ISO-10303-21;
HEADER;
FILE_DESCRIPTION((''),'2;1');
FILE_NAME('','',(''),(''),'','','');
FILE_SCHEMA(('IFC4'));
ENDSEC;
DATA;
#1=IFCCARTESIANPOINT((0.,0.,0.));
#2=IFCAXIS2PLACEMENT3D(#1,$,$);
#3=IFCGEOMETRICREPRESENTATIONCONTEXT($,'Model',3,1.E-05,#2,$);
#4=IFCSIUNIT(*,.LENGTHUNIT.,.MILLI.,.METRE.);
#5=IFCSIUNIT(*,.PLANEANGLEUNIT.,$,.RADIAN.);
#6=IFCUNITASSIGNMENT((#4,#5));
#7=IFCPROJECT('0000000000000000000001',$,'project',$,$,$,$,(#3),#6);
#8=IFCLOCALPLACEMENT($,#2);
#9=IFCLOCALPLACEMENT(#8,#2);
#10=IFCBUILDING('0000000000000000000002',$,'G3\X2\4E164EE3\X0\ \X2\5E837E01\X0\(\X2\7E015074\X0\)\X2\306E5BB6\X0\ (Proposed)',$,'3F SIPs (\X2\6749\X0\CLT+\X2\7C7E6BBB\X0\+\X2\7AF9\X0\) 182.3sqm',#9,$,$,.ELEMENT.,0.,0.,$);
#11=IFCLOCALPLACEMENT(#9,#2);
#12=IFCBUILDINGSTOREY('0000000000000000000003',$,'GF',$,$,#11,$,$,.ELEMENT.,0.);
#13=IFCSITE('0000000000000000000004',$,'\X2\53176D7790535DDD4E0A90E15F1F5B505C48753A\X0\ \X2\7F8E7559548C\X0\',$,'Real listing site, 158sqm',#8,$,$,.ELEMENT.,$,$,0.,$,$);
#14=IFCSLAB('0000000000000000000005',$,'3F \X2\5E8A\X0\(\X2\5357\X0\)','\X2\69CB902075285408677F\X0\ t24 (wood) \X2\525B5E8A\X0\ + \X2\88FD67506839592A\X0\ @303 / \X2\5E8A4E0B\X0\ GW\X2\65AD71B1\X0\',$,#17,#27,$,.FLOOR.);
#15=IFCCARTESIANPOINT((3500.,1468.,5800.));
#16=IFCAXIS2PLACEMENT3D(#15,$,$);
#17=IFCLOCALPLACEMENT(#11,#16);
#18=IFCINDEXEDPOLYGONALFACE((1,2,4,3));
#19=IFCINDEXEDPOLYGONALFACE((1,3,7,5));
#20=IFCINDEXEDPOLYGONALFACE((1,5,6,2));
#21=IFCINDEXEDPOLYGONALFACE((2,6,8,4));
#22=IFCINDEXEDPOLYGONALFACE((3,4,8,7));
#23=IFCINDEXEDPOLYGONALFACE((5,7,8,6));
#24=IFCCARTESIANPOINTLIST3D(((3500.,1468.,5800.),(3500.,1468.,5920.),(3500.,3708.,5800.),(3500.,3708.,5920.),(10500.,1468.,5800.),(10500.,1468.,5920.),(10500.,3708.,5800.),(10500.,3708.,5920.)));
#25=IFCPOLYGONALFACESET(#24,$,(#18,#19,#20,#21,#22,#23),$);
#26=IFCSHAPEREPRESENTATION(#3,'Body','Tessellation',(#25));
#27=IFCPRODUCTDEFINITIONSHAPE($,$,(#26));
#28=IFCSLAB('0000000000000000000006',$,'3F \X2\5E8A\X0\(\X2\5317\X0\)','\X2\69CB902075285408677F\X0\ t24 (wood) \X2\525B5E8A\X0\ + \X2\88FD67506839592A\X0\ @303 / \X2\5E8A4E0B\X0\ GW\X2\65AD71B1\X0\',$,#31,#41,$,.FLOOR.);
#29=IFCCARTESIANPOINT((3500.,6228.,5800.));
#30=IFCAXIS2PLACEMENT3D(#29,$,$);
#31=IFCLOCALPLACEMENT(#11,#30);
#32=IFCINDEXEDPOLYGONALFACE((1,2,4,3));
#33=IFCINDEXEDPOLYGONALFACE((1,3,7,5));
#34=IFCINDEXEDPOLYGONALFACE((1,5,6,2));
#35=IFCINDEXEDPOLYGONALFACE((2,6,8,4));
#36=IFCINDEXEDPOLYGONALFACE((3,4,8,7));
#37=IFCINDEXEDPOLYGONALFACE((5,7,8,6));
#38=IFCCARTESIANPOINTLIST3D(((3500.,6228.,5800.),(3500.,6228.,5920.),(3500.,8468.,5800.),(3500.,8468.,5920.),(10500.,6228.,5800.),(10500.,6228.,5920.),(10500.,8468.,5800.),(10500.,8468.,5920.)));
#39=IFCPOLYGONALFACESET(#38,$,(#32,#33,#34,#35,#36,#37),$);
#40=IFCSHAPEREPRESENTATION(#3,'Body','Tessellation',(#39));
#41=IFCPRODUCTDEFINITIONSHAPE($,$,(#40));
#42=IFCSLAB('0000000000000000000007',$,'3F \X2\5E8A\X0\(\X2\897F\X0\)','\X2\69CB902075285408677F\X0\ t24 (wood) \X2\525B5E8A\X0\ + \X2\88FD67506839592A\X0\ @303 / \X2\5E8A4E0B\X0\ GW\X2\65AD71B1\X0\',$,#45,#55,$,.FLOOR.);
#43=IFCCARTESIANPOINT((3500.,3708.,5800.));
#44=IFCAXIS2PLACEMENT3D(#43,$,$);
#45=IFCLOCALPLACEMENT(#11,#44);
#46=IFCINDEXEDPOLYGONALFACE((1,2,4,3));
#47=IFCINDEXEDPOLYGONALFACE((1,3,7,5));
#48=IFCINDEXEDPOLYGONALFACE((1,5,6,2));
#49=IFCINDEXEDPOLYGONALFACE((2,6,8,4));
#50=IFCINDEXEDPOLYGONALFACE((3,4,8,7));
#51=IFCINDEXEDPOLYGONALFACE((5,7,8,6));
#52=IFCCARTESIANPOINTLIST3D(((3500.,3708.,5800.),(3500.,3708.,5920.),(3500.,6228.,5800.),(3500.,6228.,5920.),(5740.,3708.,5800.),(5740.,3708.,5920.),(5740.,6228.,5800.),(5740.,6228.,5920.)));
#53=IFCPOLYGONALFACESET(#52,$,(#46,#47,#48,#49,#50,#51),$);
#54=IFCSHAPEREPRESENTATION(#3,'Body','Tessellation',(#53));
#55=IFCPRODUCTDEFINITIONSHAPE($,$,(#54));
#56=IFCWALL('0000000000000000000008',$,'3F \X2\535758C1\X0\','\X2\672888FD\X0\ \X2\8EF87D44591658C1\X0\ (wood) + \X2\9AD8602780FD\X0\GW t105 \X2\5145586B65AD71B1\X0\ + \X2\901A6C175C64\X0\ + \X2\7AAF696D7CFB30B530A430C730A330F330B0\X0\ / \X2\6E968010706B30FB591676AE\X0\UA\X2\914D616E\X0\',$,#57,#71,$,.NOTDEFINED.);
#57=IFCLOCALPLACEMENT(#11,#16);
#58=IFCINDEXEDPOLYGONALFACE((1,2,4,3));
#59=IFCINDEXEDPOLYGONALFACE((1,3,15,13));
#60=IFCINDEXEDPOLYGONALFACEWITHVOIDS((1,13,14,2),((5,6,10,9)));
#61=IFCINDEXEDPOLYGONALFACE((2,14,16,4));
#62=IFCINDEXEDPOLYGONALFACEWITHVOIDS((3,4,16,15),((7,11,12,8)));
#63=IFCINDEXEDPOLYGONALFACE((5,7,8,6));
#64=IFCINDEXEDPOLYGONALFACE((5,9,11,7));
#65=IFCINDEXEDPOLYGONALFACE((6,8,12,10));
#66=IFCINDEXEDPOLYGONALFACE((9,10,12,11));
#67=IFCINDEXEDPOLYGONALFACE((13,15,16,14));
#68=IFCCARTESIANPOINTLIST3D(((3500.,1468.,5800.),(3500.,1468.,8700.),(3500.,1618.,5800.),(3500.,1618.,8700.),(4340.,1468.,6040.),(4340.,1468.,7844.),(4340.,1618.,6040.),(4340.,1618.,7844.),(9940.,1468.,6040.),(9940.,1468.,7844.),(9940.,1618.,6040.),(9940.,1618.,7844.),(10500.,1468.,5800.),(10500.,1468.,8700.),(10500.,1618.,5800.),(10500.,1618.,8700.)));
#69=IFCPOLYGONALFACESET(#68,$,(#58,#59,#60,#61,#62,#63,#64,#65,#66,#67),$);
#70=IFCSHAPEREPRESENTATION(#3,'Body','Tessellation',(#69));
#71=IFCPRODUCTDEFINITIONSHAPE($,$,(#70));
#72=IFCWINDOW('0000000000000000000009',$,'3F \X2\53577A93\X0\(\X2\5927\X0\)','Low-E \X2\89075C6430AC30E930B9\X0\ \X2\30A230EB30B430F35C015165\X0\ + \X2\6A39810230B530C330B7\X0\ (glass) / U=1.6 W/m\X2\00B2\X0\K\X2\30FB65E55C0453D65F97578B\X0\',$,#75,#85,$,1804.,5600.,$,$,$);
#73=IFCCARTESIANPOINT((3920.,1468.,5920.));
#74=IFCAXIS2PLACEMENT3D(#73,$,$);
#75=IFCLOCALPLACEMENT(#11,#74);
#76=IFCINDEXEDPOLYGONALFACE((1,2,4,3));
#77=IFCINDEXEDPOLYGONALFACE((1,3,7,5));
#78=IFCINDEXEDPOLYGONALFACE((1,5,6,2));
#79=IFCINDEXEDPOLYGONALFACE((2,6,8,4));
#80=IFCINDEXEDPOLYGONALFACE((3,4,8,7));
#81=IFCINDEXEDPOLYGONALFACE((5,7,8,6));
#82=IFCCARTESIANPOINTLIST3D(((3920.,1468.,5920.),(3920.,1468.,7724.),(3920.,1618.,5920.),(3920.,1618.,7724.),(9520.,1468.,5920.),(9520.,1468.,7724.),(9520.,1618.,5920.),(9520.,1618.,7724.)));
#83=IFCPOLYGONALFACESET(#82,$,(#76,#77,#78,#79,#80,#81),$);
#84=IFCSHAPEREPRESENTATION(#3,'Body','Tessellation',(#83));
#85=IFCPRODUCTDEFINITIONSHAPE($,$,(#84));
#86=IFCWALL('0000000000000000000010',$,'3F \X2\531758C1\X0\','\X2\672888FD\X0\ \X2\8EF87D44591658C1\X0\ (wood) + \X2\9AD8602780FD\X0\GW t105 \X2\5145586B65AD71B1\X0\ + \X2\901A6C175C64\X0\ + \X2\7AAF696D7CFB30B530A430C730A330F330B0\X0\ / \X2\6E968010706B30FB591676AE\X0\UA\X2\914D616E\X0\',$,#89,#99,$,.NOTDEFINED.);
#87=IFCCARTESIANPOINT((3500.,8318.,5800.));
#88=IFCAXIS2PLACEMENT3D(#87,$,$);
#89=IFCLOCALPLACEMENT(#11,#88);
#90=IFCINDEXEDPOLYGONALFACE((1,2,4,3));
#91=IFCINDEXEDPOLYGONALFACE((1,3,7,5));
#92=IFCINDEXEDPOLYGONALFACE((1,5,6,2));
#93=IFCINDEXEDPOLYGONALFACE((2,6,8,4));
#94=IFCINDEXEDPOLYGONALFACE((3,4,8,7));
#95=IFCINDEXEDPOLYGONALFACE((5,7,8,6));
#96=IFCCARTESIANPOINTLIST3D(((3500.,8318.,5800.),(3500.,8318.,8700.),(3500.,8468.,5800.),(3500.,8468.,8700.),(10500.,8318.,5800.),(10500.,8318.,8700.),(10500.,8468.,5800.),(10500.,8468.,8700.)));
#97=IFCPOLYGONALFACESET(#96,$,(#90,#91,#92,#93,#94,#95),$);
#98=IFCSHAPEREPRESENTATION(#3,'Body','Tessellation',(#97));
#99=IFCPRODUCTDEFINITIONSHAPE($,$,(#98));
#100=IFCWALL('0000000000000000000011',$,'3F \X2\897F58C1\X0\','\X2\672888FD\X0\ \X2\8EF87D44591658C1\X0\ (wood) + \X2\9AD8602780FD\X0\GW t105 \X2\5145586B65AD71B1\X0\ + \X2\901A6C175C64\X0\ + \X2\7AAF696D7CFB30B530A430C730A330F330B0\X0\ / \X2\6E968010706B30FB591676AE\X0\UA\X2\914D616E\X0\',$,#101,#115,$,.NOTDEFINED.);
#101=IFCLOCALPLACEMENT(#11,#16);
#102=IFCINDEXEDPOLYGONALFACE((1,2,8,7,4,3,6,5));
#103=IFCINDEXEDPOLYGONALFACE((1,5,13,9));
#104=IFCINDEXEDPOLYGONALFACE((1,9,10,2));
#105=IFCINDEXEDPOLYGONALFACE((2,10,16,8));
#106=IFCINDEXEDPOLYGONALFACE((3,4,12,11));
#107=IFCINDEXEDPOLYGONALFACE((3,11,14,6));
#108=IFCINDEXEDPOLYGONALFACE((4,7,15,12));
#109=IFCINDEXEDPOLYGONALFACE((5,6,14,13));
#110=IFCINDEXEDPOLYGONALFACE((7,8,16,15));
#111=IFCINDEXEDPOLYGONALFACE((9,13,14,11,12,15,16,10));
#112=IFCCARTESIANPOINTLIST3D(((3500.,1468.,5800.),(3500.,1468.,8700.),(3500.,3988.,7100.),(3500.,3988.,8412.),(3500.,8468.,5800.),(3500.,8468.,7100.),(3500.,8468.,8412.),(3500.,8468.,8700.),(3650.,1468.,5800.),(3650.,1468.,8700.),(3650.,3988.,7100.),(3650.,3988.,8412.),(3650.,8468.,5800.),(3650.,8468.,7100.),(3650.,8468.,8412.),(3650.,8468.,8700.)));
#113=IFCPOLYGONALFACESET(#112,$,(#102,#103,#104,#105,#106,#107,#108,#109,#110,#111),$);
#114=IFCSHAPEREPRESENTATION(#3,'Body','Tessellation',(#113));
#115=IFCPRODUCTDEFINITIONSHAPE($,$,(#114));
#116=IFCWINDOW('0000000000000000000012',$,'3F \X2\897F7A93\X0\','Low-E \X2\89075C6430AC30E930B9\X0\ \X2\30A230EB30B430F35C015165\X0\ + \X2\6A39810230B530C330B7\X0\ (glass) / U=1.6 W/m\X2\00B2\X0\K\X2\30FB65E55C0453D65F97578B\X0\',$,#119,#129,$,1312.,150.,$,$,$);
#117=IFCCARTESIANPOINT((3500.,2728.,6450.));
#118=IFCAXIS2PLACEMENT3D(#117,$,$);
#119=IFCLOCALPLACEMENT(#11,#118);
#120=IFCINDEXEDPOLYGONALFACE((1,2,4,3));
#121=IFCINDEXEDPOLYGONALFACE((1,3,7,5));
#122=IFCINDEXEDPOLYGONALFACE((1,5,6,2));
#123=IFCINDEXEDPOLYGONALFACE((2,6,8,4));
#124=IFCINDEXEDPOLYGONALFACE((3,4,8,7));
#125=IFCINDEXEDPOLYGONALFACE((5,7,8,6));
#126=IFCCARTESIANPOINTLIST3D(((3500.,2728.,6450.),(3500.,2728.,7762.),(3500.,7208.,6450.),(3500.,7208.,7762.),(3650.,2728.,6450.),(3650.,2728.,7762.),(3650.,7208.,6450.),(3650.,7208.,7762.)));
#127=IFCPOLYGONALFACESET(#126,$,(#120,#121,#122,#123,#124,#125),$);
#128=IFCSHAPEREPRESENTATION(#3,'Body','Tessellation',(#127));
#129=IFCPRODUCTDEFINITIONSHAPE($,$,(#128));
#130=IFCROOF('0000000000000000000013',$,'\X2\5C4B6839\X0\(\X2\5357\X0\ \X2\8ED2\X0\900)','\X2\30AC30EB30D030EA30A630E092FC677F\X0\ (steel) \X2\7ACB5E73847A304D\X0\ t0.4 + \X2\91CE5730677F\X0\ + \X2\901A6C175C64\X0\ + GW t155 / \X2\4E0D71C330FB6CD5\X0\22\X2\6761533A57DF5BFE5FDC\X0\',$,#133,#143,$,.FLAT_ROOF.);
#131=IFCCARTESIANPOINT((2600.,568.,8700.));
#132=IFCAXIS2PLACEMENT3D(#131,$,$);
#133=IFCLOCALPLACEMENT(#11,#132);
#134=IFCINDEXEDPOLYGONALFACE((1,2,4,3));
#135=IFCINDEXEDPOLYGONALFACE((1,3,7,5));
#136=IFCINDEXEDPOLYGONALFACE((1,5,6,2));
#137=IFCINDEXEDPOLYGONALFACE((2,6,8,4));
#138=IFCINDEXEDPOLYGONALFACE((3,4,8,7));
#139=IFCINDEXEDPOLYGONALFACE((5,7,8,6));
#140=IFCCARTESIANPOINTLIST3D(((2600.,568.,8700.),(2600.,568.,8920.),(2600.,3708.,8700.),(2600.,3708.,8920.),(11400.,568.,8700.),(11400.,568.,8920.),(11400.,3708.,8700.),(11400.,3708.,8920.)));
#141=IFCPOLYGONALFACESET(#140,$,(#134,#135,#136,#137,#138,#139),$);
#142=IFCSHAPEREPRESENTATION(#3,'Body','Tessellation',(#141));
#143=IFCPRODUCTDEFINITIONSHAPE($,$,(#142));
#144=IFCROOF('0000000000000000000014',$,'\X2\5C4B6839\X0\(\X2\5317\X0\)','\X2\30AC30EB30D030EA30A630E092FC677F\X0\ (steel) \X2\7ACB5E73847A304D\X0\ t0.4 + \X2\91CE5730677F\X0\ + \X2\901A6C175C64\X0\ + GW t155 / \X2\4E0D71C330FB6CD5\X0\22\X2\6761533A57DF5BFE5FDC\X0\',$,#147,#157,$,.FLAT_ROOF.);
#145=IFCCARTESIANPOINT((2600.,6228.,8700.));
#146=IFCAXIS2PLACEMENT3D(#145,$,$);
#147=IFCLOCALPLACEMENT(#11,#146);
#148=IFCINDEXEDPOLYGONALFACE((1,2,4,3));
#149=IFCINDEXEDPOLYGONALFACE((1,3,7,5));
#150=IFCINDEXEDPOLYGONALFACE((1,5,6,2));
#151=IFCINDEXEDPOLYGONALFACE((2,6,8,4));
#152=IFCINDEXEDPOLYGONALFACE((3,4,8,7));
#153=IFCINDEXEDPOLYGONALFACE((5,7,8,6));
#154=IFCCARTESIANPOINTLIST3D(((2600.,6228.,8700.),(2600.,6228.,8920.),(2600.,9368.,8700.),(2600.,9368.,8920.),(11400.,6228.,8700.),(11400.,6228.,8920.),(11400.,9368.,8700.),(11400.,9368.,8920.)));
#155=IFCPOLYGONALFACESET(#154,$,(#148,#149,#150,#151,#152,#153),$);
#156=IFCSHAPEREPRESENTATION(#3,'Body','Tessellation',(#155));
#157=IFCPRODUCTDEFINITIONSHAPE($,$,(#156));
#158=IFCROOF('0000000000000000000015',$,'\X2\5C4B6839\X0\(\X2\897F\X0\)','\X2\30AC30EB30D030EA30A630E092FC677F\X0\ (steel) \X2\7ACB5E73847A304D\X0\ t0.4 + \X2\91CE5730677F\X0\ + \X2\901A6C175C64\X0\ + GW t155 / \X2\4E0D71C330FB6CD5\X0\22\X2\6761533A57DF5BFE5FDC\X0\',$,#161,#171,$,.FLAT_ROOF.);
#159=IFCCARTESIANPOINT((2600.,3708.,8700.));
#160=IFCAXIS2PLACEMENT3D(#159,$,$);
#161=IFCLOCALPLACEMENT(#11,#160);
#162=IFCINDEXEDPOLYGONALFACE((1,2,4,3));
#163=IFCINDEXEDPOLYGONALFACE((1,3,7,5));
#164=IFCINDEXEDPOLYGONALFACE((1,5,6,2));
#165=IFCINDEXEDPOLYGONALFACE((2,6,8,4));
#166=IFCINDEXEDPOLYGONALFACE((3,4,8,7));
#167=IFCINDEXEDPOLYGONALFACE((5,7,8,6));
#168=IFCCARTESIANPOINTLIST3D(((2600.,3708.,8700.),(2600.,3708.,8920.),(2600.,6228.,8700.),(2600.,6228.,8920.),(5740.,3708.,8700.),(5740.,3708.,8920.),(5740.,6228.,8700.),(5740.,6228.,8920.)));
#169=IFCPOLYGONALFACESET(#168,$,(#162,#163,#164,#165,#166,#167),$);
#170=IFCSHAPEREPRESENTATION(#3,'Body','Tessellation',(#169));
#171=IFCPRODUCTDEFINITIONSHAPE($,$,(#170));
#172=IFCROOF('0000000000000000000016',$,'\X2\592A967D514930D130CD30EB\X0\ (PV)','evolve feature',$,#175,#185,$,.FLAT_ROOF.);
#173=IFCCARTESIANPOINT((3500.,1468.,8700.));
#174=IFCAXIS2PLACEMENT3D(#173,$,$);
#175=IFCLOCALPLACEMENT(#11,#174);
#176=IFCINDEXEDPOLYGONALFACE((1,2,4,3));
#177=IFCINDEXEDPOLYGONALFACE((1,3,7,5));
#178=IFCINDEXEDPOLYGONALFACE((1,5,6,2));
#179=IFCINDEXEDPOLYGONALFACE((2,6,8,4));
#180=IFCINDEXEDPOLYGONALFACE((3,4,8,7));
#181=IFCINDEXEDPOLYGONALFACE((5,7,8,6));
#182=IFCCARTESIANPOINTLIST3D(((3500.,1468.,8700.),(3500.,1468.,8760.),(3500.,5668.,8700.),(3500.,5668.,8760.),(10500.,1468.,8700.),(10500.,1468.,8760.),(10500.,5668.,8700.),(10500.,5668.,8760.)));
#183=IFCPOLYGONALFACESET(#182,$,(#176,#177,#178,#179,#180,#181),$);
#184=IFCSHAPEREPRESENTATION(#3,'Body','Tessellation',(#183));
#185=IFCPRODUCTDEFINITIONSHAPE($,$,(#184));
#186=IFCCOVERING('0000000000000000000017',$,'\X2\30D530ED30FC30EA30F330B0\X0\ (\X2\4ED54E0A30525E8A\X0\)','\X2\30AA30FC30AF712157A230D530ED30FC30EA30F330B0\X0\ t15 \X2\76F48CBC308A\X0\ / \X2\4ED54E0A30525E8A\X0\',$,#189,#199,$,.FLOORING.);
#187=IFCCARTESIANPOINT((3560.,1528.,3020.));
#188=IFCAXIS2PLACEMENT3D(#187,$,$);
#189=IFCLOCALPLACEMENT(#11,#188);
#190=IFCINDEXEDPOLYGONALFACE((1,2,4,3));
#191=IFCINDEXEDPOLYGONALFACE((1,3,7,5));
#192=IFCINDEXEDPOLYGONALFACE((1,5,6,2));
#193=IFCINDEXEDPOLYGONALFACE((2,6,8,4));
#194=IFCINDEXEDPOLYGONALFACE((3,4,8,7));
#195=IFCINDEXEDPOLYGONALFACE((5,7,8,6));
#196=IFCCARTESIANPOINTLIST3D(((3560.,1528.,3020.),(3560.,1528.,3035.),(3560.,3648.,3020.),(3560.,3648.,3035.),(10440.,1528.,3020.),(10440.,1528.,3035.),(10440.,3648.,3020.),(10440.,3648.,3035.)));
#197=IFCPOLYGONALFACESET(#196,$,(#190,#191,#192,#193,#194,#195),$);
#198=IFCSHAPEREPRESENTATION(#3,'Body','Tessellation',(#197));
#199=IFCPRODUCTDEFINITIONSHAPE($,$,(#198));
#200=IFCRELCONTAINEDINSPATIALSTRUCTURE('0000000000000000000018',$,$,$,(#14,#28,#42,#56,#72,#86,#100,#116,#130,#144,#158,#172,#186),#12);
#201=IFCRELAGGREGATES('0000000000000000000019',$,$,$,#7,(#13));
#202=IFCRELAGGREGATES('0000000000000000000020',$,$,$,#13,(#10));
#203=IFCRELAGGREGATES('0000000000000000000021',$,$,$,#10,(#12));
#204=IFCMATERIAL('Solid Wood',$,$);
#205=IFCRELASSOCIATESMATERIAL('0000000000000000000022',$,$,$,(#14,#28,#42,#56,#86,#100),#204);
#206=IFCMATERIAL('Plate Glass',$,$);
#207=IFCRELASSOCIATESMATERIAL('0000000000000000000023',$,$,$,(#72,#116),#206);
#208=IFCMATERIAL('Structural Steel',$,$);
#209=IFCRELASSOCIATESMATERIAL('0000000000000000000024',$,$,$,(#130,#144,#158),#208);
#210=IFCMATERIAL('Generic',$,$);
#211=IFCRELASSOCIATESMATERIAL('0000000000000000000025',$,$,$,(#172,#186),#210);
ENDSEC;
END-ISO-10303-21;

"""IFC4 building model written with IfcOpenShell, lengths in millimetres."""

from ifc_helpers import new_model, si_unit, frame, frame_2d, origin, place, context, project, spatial, rectangle, extrude, material, element, fill, save


model = new_model("IFC4")

# Units and contexts
model_context = context("Model", 3, precision=1e-05, world=origin())
ifc_project = project(units=[si_unit("LENGTHUNIT", "METRE", prefix="MILLI"), si_unit("PLANEANGLEUNIT", "RADIAN")], contexts=[model_context])

# Site, building, storey
site_placement = place(None, origin())
site = spatial("IfcSite", under=ifc_project, at=site_placement, Name="北海道川上郡弟子屈町 美留和", ObjectType="Real listing site, 158sqm", CompositionType="ELEMENT", RefElevation=0.0)
building_placement = place(site_placement, origin())
building = spatial("IfcBuilding", under=site, at=building_placement, Name="G3世代 広縁(縁側)の家 (Proposed)", ObjectType="3F SIPs (杉CLT+籾殻+竹) 182.3sqm", CompositionType="ELEMENT", ElevationOfRefHeight=0.0, ElevationOfTerrain=0.0)
storey_placement = place(building_placement, origin())
storey = spatial("IfcBuildingStorey", under=building, at=storey_placement, Name="GF", CompositionType="ELEMENT", Elevation=0.0)

# Slabs
ifc_material_1 = material(Name="Solid Wood")
slab_1_placement = place(storey_placement, frame((3500.0, 1468.0, 5800.0)))
element("IfcSlab", 1, at=slab_1_placement, inside=storey, material=ifc_material_1, Name="3F 床(南)", Description="構造用合板 t24 (wood) 剛床 + 製材根太 @303 / 床下 GW断熱", PredefinedType="FLOOR", context=model_context, shape_type="SweptSolid", body=[
    extrude(rectangle(XDim=7000.0, YDim=2240.0, at=frame_2d((3500.0, 1120.0))), frame((3500.0, 1468.0, 5800.0)), (0.0, 0.0, 1.0), 120.0),
])
slab_2_placement = place(storey_placement, frame((3500.0, 6228.0, 5800.0)))
element("IfcSlab", 2, at=slab_2_placement, inside=storey, material=ifc_material_1, Name="3F 床(北)", Description="構造用合板 t24 (wood) 剛床 + 製材根太 @303 / 床下 GW断熱", PredefinedType="FLOOR", context=model_context, shape_type="SweptSolid", body=[
    extrude(rectangle(XDim=7000.0, YDim=2240.0, at=frame_2d((3500.0, 1120.0))), frame((3500.0, 6228.0, 5800.0)), (0.0, 0.0, 1.0), 120.0),
])
slab_3_placement = place(storey_placement, frame((3500.0, 3708.0, 5800.0)))
element("IfcSlab", 3, at=slab_3_placement, inside=storey, material=ifc_material_1, Name="3F 床(西)", Description="構造用合板 t24 (wood) 剛床 + 製材根太 @303 / 床下 GW断熱", PredefinedType="FLOOR", context=model_context, shape_type="SweptSolid", body=[
    extrude(rectangle(XDim=2240.0, YDim=2520.0, at=frame_2d((1120.0, 1260.0))), frame((3500.0, 3708.0, 5800.0)), (0.0, 0.0, 1.0), 120.0),
])

# Wall, opening, window
wall_1_placement = place(storey_placement, frame((3500.0, 1468.0, 5800.0)))
wall_1 = element("IfcWall", 4, at=wall_1_placement, inside=storey, material=ifc_material_1, Name="3F 南壁", Description="木製 軸組外壁 (wood) + 高性能GW t105 充填断熱 + 通気層 + 窯業系サイディング / 準耐火・外皮UA配慮", PredefinedType="NOTDEFINED", context=model_context, shape_type="SweptSolid", body=[
    extrude(rectangle(XDim=7000.0, YDim=150.0, at=frame_2d((3500.0, 75.0))), frame((3500.0, 1468.0, 5800.0)), (0.0, 0.0, 1.0), 2900.0),
])
opening_1_placement = place(storey_placement, frame((3920.0, 1468.0, 5920.0)))
opening_1 = element("IfcOpeningElement", 5, at=opening_1_placement, cuts=wall_1, PredefinedType="NOTDEFINED", context=model_context, shape_type="SweptSolid", body=[
    extrude(rectangle(XDim=5600.0, YDim=150.0, at=frame_2d((2800.0, 75.0))), frame((3920.0, 1468.0, 5920.0)), (0.0, 0.0, 1.0), 1804.0),
])
ifc_material_2 = material(Name="Plate Glass")
window_1_placement = place(storey_placement, frame((3920.0, 1468.0, 5920.0)))
window_1 = element("IfcWindow", 6, at=window_1_placement, inside=storey, material=ifc_material_2, Name="3F 南窓(大)", Description="Low-E 複層ガラス アルゴン封入 + 樹脂サッシ (glass) / U=1.6 W/m²K・日射取得型", OverallHeight=1804.0, OverallWidth=5600.0, context=model_context, shape_type="SweptSolid", body=[
    extrude(rectangle(XDim=5600.0, YDim=150.0, at=frame_2d((2800.0, 75.0))), frame((3920.0, 1468.0, 5920.0)), (0.0, 0.0, 1.0), 1804.0),
])
fill(opening_1, window_1)

# Wall
wall_2_placement = place(storey_placement, frame((3500.0, 8318.0, 5800.0)))
element("IfcWall", 7, at=wall_2_placement, inside=storey, material=ifc_material_1, Name="3F 北壁", Description="木製 軸組外壁 (wood) + 高性能GW t105 充填断熱 + 通気層 + 窯業系サイディング / 準耐火・外皮UA配慮", PredefinedType="NOTDEFINED", context=model_context, shape_type="SweptSolid", body=[
    extrude(rectangle(XDim=7000.0, YDim=150.0, at=frame_2d((3500.0, 75.0))), frame((3500.0, 8318.0, 5800.0)), (0.0, 0.0, 1.0), 2900.0),
])

# Wall, opening, window
wall_3_placement = place(storey_placement, frame((3500.0, 1468.0, 5800.0)))
wall_3 = element("IfcWall", 8, at=wall_3_placement, inside=storey, material=ifc_material_1, Name="3F 西壁", Description="木製 軸組外壁 (wood) + 高性能GW t105 充填断熱 + 通気層 + 窯業系サイディング / 準耐火・外皮UA配慮", PredefinedType="NOTDEFINED", context=model_context, shape_type="SweptSolid", body=[
    extrude(rectangle(XDim=150.0, YDim=7000.0, at=frame_2d((75.0, 3500.0))), frame((3500.0, 1468.0, 5800.0)), (0.0, 0.0, 1.0), 2900.0),
])
opening_2_placement = place(storey_placement, frame((3500.0, 2728.0, 6450.0)))
opening_2 = element("IfcOpeningElement", 9, at=opening_2_placement, cuts=wall_3, PredefinedType="NOTDEFINED", context=model_context, shape_type="SweptSolid", body=[
    extrude(rectangle(XDim=150.0, YDim=4480.0, at=frame_2d((75.0, 2240.0))), frame((3500.0, 2728.0, 6450.0)), (0.0, 0.0, 1.0), 1312.0),
])
window_2_placement = place(storey_placement, frame((3500.0, 2728.0, 6450.0)))
window_2 = element("IfcWindow", 10, at=window_2_placement, inside=storey, material=ifc_material_2, Name="3F 西窓", Description="Low-E 複層ガラス アルゴン封入 + 樹脂サッシ (glass) / U=1.6 W/m²K・日射取得型", OverallHeight=1312.0, OverallWidth=150.0, context=model_context, shape_type="SweptSolid", body=[
    extrude(rectangle(XDim=150.0, YDim=4480.0, at=frame_2d((75.0, 2240.0))), frame((3500.0, 2728.0, 6450.0)), (0.0, 0.0, 1.0), 1312.0),
])
fill(opening_2, window_2)

# Roofs
ifc_material_3 = material(Name="Structural Steel")
roof_1_placement = place(storey_placement, frame((2600.0, 568.0, 8700.0)))
element("IfcRoof", 11, at=roof_1_placement, inside=storey, material=ifc_material_3, Name="屋根(南 軒900)", Description="ガルバリウム鋼板 (steel) 立平葺き t0.4 + 野地板 + 通気層 + GW t155 / 不燃・法22条区域対応", PredefinedType="FLAT_ROOF", context=model_context, shape_type="SweptSolid", body=[
    extrude(rectangle(XDim=8800.0, YDim=3140.0, at=frame_2d((4400.0, 1570.0))), frame((2600.0, 568.0, 8700.0)), (0.0, 0.0, 1.0), 220.0),
])
roof_2_placement = place(storey_placement, frame((2600.0, 6228.0, 8700.0)))
element("IfcRoof", 12, at=roof_2_placement, inside=storey, material=ifc_material_3, Name="屋根(北)", Description="ガルバリウム鋼板 (steel) 立平葺き t0.4 + 野地板 + 通気層 + GW t155 / 不燃・法22条区域対応", PredefinedType="FLAT_ROOF", context=model_context, shape_type="SweptSolid", body=[
    extrude(rectangle(XDim=8800.0, YDim=3140.0, at=frame_2d((4400.0, 1570.0))), frame((2600.0, 6228.0, 8700.0)), (0.0, 0.0, 1.0), 220.0),
])
roof_3_placement = place(storey_placement, frame((2600.0, 3708.0, 8700.0)))
element("IfcRoof", 13, at=roof_3_placement, inside=storey, material=ifc_material_3, Name="屋根(西)", Description="ガルバリウム鋼板 (steel) 立平葺き t0.4 + 野地板 + 通気層 + GW t155 / 不燃・法22条区域対応", PredefinedType="FLAT_ROOF", context=model_context, shape_type="SweptSolid", body=[
    extrude(rectangle(XDim=3140.0, YDim=2520.0, at=frame_2d((1570.0, 1260.0))), frame((2600.0, 3708.0, 8700.0)), (0.0, 0.0, 1.0), 220.0),
])
ifc_material_4 = material(Name="Generic")
roof_4_placement = place(storey_placement, frame((3500.0, 1468.0, 8700.0)))
element("IfcRoof", 14, at=roof_4_placement, inside=storey, material=ifc_material_4, Name="太陽光パネル (PV)", Description="evolve feature", PredefinedType="FLAT_ROOF", context=model_context, shape_type="SweptSolid", body=[
    extrude(rectangle(XDim=7000.0, YDim=4200.0, at=frame_2d((3500.0, 2100.0))), frame((3500.0, 1468.0, 8700.0)), (0.0, 0.0, 1.0), 60.0),
])

# Covering
covering_1_placement = place(storey_placement, frame((3560.0, 1528.0, 3020.0)))
element("IfcCovering", 15, at=covering_1_placement, inside=storey, material=ifc_material_4, Name="フローリング (仕上げ床)", Description="オーク無垢フローリング t15 直貼り / 仕上げ床", PredefinedType="FLOORING", context=model_context, shape_type="SweptSolid", body=[
    extrude(rectangle(XDim=6880.0, YDim=2120.0, at=frame_2d((3440.0, 1060.0))), frame((3560.0, 1528.0, 3020.0)), (0.0, 0.0, 1.0), 15.0),
])

save(model, "model.ifc")
